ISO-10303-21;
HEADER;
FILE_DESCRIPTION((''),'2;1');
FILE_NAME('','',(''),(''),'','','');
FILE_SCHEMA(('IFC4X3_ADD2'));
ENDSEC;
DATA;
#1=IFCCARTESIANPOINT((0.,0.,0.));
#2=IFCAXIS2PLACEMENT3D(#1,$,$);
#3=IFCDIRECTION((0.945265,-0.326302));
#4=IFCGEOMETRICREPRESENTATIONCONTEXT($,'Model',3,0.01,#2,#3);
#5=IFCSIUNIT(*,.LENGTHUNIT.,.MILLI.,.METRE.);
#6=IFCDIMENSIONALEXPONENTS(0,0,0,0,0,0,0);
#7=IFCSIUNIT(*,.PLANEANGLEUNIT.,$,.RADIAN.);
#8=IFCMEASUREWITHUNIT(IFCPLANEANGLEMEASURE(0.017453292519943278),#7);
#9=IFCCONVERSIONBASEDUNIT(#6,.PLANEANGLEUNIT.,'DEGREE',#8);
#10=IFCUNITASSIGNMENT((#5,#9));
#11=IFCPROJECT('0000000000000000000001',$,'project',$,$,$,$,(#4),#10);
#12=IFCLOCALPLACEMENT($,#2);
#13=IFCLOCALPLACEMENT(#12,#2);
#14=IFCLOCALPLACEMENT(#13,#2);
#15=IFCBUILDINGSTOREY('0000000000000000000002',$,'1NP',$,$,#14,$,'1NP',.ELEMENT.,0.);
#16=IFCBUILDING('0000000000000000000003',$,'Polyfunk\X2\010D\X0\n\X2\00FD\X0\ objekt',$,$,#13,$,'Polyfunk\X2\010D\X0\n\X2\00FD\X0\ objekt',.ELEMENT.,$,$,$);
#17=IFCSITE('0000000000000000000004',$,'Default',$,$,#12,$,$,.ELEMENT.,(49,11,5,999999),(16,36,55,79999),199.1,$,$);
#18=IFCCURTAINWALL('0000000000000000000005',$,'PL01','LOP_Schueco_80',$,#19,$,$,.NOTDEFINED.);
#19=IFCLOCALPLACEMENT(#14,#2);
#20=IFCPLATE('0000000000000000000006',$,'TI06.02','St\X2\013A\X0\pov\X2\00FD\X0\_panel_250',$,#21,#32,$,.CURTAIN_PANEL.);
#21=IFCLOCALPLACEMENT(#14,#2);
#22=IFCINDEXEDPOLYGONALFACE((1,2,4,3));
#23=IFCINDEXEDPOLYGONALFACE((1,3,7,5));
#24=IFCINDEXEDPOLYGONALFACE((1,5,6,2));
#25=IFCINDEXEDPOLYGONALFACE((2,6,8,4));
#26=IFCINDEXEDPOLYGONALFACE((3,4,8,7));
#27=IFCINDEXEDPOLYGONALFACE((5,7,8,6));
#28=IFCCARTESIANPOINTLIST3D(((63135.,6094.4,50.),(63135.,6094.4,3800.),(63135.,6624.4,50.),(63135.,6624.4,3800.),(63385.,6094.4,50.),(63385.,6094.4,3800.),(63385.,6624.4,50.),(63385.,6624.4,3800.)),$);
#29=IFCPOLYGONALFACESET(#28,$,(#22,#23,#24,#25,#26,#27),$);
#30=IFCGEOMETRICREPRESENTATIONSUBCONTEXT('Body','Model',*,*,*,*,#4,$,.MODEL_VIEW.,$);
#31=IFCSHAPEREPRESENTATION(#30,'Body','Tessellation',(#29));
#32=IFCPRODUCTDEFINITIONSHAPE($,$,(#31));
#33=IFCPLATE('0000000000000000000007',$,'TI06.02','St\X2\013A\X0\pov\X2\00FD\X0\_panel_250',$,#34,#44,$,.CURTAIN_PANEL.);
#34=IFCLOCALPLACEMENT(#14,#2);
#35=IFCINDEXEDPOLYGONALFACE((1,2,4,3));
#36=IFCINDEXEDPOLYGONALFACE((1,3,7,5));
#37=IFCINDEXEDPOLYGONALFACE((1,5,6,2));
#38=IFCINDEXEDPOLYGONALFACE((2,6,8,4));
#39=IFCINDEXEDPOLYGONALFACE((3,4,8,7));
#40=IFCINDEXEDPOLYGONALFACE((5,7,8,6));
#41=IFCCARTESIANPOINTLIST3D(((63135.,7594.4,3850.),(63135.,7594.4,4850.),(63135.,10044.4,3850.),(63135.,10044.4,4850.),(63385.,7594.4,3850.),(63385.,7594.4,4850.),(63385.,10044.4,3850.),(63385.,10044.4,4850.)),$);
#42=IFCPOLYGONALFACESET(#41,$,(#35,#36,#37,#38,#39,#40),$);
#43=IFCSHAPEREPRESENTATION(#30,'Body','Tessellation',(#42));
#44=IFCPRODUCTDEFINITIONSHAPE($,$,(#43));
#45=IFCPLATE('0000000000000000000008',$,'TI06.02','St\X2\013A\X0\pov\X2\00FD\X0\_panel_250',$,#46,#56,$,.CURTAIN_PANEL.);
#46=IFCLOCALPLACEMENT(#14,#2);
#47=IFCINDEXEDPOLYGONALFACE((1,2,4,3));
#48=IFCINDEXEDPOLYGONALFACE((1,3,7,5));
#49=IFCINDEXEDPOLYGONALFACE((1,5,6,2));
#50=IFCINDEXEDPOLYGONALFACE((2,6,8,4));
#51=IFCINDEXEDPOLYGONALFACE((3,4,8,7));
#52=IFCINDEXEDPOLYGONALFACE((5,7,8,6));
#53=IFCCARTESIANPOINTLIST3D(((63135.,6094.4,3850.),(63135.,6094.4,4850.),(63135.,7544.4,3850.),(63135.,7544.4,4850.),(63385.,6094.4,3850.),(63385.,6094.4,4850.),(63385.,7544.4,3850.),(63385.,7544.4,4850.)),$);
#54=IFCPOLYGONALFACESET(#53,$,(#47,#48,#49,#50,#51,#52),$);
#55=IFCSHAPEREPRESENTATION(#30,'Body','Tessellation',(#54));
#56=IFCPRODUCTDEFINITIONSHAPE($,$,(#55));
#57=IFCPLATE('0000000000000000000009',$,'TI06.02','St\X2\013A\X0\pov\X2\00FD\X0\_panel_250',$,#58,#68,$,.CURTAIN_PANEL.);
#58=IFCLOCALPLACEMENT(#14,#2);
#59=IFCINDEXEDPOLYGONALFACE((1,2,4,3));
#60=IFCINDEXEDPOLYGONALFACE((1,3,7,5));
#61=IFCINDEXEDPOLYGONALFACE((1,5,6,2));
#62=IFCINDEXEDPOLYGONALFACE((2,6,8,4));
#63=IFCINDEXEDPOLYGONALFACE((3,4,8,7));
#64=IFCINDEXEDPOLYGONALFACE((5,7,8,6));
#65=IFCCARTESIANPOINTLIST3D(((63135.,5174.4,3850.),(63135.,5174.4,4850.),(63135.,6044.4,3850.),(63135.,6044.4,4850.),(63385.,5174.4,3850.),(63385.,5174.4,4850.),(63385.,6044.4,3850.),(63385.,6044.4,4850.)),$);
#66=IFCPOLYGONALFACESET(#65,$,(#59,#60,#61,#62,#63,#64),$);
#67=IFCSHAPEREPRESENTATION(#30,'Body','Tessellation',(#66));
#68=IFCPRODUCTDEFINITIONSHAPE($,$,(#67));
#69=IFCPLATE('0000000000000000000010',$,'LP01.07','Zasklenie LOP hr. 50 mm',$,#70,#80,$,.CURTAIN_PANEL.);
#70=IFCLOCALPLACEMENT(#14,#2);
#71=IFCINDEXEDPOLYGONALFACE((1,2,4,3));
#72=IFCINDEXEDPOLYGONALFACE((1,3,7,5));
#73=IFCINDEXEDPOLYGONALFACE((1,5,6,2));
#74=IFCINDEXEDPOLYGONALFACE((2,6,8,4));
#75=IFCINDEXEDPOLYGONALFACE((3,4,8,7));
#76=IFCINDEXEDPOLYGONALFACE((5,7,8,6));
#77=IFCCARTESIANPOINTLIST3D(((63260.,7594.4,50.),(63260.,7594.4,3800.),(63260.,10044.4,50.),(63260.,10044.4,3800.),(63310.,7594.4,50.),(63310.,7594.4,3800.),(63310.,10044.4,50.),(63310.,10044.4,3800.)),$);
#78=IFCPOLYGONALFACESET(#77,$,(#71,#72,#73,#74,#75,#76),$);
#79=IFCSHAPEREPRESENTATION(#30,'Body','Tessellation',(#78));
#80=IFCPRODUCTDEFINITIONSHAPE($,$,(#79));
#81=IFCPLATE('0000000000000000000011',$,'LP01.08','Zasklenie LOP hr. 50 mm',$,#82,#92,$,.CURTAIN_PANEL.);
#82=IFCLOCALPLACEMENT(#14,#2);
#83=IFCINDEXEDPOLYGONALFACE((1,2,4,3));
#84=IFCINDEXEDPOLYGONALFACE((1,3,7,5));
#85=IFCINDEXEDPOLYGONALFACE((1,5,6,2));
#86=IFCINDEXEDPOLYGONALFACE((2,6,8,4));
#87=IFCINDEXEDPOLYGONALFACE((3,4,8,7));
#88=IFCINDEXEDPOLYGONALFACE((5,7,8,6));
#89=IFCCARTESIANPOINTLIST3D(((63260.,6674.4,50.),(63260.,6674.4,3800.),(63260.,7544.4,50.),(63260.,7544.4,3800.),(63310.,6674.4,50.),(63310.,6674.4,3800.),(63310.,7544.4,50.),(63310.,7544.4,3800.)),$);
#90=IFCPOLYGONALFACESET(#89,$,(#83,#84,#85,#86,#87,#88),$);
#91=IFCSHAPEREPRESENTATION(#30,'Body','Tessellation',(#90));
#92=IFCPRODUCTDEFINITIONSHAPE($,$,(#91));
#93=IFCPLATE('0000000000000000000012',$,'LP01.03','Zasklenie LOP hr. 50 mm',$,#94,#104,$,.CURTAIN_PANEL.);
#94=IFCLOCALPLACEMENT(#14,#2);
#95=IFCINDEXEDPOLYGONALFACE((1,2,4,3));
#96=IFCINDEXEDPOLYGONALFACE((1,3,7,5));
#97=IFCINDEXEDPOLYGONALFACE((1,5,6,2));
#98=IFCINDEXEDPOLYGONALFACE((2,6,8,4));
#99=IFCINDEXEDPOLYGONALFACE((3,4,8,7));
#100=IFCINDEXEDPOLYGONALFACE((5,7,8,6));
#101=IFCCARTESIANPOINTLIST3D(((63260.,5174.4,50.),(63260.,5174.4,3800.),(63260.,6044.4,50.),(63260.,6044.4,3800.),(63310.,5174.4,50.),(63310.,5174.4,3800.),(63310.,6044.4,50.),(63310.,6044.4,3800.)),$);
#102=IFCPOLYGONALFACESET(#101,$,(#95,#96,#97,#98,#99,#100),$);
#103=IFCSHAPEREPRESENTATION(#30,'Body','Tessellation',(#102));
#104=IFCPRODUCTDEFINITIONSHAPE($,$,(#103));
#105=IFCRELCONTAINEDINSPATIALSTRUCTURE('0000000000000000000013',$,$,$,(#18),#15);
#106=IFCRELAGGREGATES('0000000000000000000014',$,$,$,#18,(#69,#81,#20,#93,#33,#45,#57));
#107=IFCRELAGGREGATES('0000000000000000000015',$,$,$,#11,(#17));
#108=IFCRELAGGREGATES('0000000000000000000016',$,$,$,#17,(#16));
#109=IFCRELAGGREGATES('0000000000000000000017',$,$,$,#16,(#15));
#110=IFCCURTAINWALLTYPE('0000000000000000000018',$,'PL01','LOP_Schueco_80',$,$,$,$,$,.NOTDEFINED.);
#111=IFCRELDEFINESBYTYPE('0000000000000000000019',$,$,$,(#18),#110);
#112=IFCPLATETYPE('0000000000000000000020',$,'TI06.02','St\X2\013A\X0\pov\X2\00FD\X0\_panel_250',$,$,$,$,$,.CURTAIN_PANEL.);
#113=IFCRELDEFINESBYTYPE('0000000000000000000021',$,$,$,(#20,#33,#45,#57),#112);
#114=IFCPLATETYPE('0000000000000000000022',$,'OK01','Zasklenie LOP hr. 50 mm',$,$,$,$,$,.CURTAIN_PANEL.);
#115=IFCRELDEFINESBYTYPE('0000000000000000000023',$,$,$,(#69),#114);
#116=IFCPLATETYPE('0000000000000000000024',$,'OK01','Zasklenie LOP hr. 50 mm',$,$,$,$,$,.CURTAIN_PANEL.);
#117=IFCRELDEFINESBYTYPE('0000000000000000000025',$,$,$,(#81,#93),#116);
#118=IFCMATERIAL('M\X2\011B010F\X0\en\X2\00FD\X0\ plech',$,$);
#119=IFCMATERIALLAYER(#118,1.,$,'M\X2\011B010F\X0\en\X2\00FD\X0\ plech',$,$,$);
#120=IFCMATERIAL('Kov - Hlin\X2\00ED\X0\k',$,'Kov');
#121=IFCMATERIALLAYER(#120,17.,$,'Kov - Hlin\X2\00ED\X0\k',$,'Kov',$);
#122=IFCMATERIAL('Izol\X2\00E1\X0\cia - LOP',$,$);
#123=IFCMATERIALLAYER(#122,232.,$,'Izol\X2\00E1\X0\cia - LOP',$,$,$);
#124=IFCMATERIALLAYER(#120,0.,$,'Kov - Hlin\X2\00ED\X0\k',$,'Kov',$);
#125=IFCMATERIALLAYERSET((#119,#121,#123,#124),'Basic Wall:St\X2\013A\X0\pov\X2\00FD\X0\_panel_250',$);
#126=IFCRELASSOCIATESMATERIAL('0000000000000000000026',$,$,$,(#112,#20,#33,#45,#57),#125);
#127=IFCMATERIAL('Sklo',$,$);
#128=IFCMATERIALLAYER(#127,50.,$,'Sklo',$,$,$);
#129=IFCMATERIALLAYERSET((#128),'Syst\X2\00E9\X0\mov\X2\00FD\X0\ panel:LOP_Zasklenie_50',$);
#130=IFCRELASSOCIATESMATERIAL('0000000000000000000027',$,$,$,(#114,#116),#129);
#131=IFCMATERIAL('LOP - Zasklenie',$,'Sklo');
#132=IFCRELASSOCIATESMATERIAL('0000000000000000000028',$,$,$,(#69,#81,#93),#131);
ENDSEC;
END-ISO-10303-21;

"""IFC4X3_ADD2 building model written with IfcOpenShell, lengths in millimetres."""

from ifc_helpers import new_model, entity, si_unit, converted_unit, direction, frame, frame_2d, origin, place, context, subcontext, project, spatial, rectangle, extrude, source, transform, mapped, material, layer, layer_set, layer_usage, type_object, type_shapes, element, aggregate, save


model = new_model("IFC4X3_ADD2")

# Units and contexts
model_context = context("Model", 3, precision=0.01, world=origin(), true_north=direction((0.945265, -0.326302)))
body_context = subcontext(model_context, "Body", "Model", "MODEL_VIEW")
ifc_project = project(units=[si_unit("LENGTHUNIT", "METRE", prefix="MILLI"), converted_unit("PLANEANGLEUNIT", "DEGREE", entity("IfcPlaneAngleMeasure", 0.017453292519943278), si_unit("PLANEANGLEUNIT", "RADIAN"), dimensions=[0, 0, 0, 0, 0, 0, 0])], contexts=[model_context])

# Site, building, storey
site_placement = place(None, origin())
site = spatial("IfcSite", under=ifc_project, at=site_placement, Name="Default", CompositionType="ELEMENT", RefLatitude=(49, 11, 5, 999999), RefLongitude=(16, 36, 55, 79999), RefElevation=199.1)
building_placement = place(site_placement, origin())
building = spatial("IfcBuilding", under=site, at=building_placement, Name="Polyfunkčný objekt", LongName="Polyfunkčný objekt", CompositionType="ELEMENT")
storey_placement = place(building_placement, origin())
storey = spatial("IfcBuildingStorey", under=building, at=storey_placement, Name="1NP", LongName="1NP", CompositionType="ELEMENT", Elevation=0.0)

# Curtain wall, plates
curtain_wall_type = type_object("IfcCurtainWallType", Name="PL01", Description="LOP_Schueco_80", PredefinedType="NOTDEFINED")
curtain_wall_placement = place(storey_placement, origin())
curtain_wall = element("IfcCurtainWall", 1, at=curtain_wall_placement, inside=storey, type_object=curtain_wall_type, Name="PL01", Description="LOP_Schueco_80", PredefinedType="NOTDEFINED")
ifc_material_1 = material(Name="Měďený plech")
ifc_layer_1 = layer(ifc_material_1, 1.0, Name="Měďený plech")
ifc_material_2 = material(Name="Kov - Hliník", Category="Kov")
ifc_layer_2 = layer(ifc_material_2, 17.0, Name="Kov - Hliník", Category="Kov")
ifc_material_3 = material(Name="Izolácia - LOP")
ifc_layer_3 = layer(ifc_material_3, 232.0, Name="Izolácia - LOP")
ifc_layer_4 = layer(ifc_material_2, 0.0, Name="Kov - Hliník", Category="Kov")
ifc_layer_set_1 = layer_set([ifc_layer_1, ifc_layer_2, ifc_layer_3, ifc_layer_4], Name="Basic Wall:Stĺpový_panel_250")
ifc_layer_usage_1 = layer_usage(ifc_layer_set_1, "AXIS2", "NEGATIVE", 125.0)
plate_type_1 = type_object("IfcPlateType", Name="TI06.02", Description="Stĺpový_panel_250", PredefinedType="CURTAIN_PANEL", material=ifc_layer_set_1)
plate_1_placement = place(storey_placement, frame((63260.0, 6624.4, 50.0), z_axis=(0.0, 0.0, 1.0), x_axis=(0.0, -1.0, 0.0)))
plate_1 = element("IfcPlate", 2, at=plate_1_placement, type_object=plate_type_1, material=ifc_layer_usage_1, Name="TI06.02", Description="Stĺpový_panel_250", PredefinedType="CURTAIN_PANEL", context=body_context, shape_type="SweptSolid", body=[
    extrude(rectangle(XDim=250.0, YDim=530.0, at=frame_2d((0.0, 0.0), x_axis=(1.0, 0.0))), frame((265.0, 0.0, 0.0), z_axis=(0.0, 0.0, 1.0), x_axis=(0.0, 1.0, 0.0)), (0.0, 0.0, 1.0), 3750.0),
])
ifc_layer_usage_2 = layer_usage(ifc_layer_set_1, "AXIS2", "NEGATIVE", 125.0)
plate_2_placement = place(storey_placement, frame((63260.0, 10044.4, 3850.0), z_axis=(0.0, 0.0, 1.0), x_axis=(0.0, -1.0, 0.0)))
plate_2 = element("IfcPlate", 3, at=plate_2_placement, type_object=plate_type_1, material=ifc_layer_usage_2, Name="TI06.02", Description="Stĺpový_panel_250", PredefinedType="CURTAIN_PANEL", context=body_context, shape_type="SweptSolid", body=[
    extrude(rectangle(XDim=250.0, YDim=2450.0, at=frame_2d((0.0, 0.0), x_axis=(1.0, 0.0))), frame((1225.0, 0.0, 0.0), z_axis=(0.0, 0.0, 1.0), x_axis=(0.0, 1.0, 0.0)), (0.0, 0.0, 1.0), 1000.0),
])
ifc_layer_usage_3 = layer_usage(ifc_layer_set_1, "AXIS2", "NEGATIVE", 125.0)
plate_3_placement = place(storey_placement, frame((63260.0, 7544.4, 3850.0), z_axis=(0.0, 0.0, 1.0), x_axis=(0.0, -1.0, 0.0)))
plate_3 = element("IfcPlate", 4, at=plate_3_placement, type_object=plate_type_1, material=ifc_layer_usage_3, Name="TI06.02", Description="Stĺpový_panel_250", PredefinedType="CURTAIN_PANEL", context=body_context, shape_type="SweptSolid", body=[
    extrude(rectangle(XDim=250.0, YDim=1450.0, at=frame_2d((0.0, 0.0), x_axis=(1.0, 0.0))), frame((725.0, 0.0, 0.0), z_axis=(0.0, 0.0, 1.0), x_axis=(0.0, 1.0, 0.0)), (0.0, 0.0, 1.0), 1000.0),
])
ifc_layer_usage_4 = layer_usage(ifc_layer_set_1, "AXIS2", "NEGATIVE", 125.0)
plate_4_placement = place(storey_placement, frame((63260.0, 6044.4, 3850.0), z_axis=(0.0, 0.0, 1.0), x_axis=(0.0, -1.0, 0.0)))
plate_4 = element("IfcPlate", 5, at=plate_4_placement, type_object=plate_type_1, material=ifc_layer_usage_4, Name="TI06.02", Description="Stĺpový_panel_250", PredefinedType="CURTAIN_PANEL", context=body_context, shape_type="SweptSolid", body=[
    extrude(rectangle(XDim=250.0, YDim=870.0, at=frame_2d((0.0, 0.0), x_axis=(1.0, 0.0))), frame((435.0, 0.0, 0.0), z_axis=(0.0, 0.0, 1.0), x_axis=(0.0, 1.0, 0.0)), (0.0, 0.0, 1.0), 1000.0),
])
ifc_material_4 = material(Name="LOP - Zasklenie", Category="Sklo")
ifc_material_5 = material(Name="Sklo")
ifc_layer_5 = layer(ifc_material_5, 50.0, Name="Sklo")
ifc_layer_set_2 = layer_set([ifc_layer_5], Name="Systémový panel:LOP_Zasklenie_50")
plate_type_2 = type_object("IfcPlateType", Name="OK01", Description="Zasklenie LOP hr. 50 mm", PredefinedType="CURTAIN_PANEL", material=ifc_layer_set_2)
shared_shape_1 = source(origin(), body_context, "Body", "SweptSolid", [
    extrude(rectangle(XDim=3750.0, YDim=2450.0, at=frame_2d((-141.7, 0.0), x_axis=(1.0, 0.0))), frame((0.0, 0.0, 2016.7), z_axis=(0.0, 1.0, 0.0), x_axis=(0.0, 0.0, 1.0)), (0.0, 0.0, 1.0), 50.0),
])
type_shapes(plate_type_2, [shared_shape_1])
plate_5_placement = place(curtain_wall_placement, frame((63260.0, 8819.4, 50.0), z_axis=(0.0, 0.0, 1.0), x_axis=(0.0, -1.0, 0.0)))
plate_5 = element("IfcPlate", 6, at=plate_5_placement, type_object=plate_type_2, material=ifc_material_4, Name="LP01.07", Description="Zasklenie LOP hr. 50 mm", PredefinedType="CURTAIN_PANEL", context=body_context, shape_type="MappedRepresentation", body=[
    mapped(shared_shape_1, transform((0.0, 0.0, 0.0), scale=1.0)),
])
plate_type_3 = type_object("IfcPlateType", Name="OK01", Description="Zasklenie LOP hr. 50 mm", PredefinedType="CURTAIN_PANEL", material=ifc_layer_set_2)
shared_shape_2 = source(origin(), body_context, "Body", "SweptSolid", [
    extrude(rectangle(XDim=3750.0, YDim=870.0, at=frame_2d((-141.7, 0.0), x_axis=(1.0, 0.0))), frame((0.0, 0.0, 2016.7), z_axis=(0.0, 1.0, 0.0), x_axis=(0.0, 0.0, 1.0)), (0.0, 0.0, 1.0), 50.0),
])
type_shapes(plate_type_3, [shared_shape_2])
plate_6_placement = place(curtain_wall_placement, frame((63260.0, 7109.4, 50.0), z_axis=(0.0, 0.0, 1.0), x_axis=(0.0, -1.0, 0.0)))
plate_6 = element("IfcPlate", 7, at=plate_6_placement, type_object=plate_type_3, material=ifc_material_4, Name="LP01.08", Description="Zasklenie LOP hr. 50 mm", PredefinedType="CURTAIN_PANEL", context=body_context, shape_type="MappedRepresentation", body=[
    mapped(shared_shape_2, transform((0.0, 0.0, 0.0), scale=1.0)),
])
plate_7_placement = place(curtain_wall_placement, frame((63260.0, 5609.4, 50.0), z_axis=(0.0, 0.0, 1.0), x_axis=(0.0, -1.0, 0.0)))
plate_7 = element("IfcPlate", 8, at=plate_7_placement, type_object=plate_type_3, material=ifc_material_4, Name="LP01.03", Description="Zasklenie LOP hr. 50 mm", PredefinedType="CURTAIN_PANEL", context=body_context, shape_type="MappedRepresentation", body=[
    mapped(shared_shape_2, transform((0.0, 0.0, 0.0), scale=1.0)),
])
aggregate(curtain_wall, [plate_5, plate_6, plate_1, plate_7, plate_2, plate_3, plate_4])

save(model, "model.ifc")
